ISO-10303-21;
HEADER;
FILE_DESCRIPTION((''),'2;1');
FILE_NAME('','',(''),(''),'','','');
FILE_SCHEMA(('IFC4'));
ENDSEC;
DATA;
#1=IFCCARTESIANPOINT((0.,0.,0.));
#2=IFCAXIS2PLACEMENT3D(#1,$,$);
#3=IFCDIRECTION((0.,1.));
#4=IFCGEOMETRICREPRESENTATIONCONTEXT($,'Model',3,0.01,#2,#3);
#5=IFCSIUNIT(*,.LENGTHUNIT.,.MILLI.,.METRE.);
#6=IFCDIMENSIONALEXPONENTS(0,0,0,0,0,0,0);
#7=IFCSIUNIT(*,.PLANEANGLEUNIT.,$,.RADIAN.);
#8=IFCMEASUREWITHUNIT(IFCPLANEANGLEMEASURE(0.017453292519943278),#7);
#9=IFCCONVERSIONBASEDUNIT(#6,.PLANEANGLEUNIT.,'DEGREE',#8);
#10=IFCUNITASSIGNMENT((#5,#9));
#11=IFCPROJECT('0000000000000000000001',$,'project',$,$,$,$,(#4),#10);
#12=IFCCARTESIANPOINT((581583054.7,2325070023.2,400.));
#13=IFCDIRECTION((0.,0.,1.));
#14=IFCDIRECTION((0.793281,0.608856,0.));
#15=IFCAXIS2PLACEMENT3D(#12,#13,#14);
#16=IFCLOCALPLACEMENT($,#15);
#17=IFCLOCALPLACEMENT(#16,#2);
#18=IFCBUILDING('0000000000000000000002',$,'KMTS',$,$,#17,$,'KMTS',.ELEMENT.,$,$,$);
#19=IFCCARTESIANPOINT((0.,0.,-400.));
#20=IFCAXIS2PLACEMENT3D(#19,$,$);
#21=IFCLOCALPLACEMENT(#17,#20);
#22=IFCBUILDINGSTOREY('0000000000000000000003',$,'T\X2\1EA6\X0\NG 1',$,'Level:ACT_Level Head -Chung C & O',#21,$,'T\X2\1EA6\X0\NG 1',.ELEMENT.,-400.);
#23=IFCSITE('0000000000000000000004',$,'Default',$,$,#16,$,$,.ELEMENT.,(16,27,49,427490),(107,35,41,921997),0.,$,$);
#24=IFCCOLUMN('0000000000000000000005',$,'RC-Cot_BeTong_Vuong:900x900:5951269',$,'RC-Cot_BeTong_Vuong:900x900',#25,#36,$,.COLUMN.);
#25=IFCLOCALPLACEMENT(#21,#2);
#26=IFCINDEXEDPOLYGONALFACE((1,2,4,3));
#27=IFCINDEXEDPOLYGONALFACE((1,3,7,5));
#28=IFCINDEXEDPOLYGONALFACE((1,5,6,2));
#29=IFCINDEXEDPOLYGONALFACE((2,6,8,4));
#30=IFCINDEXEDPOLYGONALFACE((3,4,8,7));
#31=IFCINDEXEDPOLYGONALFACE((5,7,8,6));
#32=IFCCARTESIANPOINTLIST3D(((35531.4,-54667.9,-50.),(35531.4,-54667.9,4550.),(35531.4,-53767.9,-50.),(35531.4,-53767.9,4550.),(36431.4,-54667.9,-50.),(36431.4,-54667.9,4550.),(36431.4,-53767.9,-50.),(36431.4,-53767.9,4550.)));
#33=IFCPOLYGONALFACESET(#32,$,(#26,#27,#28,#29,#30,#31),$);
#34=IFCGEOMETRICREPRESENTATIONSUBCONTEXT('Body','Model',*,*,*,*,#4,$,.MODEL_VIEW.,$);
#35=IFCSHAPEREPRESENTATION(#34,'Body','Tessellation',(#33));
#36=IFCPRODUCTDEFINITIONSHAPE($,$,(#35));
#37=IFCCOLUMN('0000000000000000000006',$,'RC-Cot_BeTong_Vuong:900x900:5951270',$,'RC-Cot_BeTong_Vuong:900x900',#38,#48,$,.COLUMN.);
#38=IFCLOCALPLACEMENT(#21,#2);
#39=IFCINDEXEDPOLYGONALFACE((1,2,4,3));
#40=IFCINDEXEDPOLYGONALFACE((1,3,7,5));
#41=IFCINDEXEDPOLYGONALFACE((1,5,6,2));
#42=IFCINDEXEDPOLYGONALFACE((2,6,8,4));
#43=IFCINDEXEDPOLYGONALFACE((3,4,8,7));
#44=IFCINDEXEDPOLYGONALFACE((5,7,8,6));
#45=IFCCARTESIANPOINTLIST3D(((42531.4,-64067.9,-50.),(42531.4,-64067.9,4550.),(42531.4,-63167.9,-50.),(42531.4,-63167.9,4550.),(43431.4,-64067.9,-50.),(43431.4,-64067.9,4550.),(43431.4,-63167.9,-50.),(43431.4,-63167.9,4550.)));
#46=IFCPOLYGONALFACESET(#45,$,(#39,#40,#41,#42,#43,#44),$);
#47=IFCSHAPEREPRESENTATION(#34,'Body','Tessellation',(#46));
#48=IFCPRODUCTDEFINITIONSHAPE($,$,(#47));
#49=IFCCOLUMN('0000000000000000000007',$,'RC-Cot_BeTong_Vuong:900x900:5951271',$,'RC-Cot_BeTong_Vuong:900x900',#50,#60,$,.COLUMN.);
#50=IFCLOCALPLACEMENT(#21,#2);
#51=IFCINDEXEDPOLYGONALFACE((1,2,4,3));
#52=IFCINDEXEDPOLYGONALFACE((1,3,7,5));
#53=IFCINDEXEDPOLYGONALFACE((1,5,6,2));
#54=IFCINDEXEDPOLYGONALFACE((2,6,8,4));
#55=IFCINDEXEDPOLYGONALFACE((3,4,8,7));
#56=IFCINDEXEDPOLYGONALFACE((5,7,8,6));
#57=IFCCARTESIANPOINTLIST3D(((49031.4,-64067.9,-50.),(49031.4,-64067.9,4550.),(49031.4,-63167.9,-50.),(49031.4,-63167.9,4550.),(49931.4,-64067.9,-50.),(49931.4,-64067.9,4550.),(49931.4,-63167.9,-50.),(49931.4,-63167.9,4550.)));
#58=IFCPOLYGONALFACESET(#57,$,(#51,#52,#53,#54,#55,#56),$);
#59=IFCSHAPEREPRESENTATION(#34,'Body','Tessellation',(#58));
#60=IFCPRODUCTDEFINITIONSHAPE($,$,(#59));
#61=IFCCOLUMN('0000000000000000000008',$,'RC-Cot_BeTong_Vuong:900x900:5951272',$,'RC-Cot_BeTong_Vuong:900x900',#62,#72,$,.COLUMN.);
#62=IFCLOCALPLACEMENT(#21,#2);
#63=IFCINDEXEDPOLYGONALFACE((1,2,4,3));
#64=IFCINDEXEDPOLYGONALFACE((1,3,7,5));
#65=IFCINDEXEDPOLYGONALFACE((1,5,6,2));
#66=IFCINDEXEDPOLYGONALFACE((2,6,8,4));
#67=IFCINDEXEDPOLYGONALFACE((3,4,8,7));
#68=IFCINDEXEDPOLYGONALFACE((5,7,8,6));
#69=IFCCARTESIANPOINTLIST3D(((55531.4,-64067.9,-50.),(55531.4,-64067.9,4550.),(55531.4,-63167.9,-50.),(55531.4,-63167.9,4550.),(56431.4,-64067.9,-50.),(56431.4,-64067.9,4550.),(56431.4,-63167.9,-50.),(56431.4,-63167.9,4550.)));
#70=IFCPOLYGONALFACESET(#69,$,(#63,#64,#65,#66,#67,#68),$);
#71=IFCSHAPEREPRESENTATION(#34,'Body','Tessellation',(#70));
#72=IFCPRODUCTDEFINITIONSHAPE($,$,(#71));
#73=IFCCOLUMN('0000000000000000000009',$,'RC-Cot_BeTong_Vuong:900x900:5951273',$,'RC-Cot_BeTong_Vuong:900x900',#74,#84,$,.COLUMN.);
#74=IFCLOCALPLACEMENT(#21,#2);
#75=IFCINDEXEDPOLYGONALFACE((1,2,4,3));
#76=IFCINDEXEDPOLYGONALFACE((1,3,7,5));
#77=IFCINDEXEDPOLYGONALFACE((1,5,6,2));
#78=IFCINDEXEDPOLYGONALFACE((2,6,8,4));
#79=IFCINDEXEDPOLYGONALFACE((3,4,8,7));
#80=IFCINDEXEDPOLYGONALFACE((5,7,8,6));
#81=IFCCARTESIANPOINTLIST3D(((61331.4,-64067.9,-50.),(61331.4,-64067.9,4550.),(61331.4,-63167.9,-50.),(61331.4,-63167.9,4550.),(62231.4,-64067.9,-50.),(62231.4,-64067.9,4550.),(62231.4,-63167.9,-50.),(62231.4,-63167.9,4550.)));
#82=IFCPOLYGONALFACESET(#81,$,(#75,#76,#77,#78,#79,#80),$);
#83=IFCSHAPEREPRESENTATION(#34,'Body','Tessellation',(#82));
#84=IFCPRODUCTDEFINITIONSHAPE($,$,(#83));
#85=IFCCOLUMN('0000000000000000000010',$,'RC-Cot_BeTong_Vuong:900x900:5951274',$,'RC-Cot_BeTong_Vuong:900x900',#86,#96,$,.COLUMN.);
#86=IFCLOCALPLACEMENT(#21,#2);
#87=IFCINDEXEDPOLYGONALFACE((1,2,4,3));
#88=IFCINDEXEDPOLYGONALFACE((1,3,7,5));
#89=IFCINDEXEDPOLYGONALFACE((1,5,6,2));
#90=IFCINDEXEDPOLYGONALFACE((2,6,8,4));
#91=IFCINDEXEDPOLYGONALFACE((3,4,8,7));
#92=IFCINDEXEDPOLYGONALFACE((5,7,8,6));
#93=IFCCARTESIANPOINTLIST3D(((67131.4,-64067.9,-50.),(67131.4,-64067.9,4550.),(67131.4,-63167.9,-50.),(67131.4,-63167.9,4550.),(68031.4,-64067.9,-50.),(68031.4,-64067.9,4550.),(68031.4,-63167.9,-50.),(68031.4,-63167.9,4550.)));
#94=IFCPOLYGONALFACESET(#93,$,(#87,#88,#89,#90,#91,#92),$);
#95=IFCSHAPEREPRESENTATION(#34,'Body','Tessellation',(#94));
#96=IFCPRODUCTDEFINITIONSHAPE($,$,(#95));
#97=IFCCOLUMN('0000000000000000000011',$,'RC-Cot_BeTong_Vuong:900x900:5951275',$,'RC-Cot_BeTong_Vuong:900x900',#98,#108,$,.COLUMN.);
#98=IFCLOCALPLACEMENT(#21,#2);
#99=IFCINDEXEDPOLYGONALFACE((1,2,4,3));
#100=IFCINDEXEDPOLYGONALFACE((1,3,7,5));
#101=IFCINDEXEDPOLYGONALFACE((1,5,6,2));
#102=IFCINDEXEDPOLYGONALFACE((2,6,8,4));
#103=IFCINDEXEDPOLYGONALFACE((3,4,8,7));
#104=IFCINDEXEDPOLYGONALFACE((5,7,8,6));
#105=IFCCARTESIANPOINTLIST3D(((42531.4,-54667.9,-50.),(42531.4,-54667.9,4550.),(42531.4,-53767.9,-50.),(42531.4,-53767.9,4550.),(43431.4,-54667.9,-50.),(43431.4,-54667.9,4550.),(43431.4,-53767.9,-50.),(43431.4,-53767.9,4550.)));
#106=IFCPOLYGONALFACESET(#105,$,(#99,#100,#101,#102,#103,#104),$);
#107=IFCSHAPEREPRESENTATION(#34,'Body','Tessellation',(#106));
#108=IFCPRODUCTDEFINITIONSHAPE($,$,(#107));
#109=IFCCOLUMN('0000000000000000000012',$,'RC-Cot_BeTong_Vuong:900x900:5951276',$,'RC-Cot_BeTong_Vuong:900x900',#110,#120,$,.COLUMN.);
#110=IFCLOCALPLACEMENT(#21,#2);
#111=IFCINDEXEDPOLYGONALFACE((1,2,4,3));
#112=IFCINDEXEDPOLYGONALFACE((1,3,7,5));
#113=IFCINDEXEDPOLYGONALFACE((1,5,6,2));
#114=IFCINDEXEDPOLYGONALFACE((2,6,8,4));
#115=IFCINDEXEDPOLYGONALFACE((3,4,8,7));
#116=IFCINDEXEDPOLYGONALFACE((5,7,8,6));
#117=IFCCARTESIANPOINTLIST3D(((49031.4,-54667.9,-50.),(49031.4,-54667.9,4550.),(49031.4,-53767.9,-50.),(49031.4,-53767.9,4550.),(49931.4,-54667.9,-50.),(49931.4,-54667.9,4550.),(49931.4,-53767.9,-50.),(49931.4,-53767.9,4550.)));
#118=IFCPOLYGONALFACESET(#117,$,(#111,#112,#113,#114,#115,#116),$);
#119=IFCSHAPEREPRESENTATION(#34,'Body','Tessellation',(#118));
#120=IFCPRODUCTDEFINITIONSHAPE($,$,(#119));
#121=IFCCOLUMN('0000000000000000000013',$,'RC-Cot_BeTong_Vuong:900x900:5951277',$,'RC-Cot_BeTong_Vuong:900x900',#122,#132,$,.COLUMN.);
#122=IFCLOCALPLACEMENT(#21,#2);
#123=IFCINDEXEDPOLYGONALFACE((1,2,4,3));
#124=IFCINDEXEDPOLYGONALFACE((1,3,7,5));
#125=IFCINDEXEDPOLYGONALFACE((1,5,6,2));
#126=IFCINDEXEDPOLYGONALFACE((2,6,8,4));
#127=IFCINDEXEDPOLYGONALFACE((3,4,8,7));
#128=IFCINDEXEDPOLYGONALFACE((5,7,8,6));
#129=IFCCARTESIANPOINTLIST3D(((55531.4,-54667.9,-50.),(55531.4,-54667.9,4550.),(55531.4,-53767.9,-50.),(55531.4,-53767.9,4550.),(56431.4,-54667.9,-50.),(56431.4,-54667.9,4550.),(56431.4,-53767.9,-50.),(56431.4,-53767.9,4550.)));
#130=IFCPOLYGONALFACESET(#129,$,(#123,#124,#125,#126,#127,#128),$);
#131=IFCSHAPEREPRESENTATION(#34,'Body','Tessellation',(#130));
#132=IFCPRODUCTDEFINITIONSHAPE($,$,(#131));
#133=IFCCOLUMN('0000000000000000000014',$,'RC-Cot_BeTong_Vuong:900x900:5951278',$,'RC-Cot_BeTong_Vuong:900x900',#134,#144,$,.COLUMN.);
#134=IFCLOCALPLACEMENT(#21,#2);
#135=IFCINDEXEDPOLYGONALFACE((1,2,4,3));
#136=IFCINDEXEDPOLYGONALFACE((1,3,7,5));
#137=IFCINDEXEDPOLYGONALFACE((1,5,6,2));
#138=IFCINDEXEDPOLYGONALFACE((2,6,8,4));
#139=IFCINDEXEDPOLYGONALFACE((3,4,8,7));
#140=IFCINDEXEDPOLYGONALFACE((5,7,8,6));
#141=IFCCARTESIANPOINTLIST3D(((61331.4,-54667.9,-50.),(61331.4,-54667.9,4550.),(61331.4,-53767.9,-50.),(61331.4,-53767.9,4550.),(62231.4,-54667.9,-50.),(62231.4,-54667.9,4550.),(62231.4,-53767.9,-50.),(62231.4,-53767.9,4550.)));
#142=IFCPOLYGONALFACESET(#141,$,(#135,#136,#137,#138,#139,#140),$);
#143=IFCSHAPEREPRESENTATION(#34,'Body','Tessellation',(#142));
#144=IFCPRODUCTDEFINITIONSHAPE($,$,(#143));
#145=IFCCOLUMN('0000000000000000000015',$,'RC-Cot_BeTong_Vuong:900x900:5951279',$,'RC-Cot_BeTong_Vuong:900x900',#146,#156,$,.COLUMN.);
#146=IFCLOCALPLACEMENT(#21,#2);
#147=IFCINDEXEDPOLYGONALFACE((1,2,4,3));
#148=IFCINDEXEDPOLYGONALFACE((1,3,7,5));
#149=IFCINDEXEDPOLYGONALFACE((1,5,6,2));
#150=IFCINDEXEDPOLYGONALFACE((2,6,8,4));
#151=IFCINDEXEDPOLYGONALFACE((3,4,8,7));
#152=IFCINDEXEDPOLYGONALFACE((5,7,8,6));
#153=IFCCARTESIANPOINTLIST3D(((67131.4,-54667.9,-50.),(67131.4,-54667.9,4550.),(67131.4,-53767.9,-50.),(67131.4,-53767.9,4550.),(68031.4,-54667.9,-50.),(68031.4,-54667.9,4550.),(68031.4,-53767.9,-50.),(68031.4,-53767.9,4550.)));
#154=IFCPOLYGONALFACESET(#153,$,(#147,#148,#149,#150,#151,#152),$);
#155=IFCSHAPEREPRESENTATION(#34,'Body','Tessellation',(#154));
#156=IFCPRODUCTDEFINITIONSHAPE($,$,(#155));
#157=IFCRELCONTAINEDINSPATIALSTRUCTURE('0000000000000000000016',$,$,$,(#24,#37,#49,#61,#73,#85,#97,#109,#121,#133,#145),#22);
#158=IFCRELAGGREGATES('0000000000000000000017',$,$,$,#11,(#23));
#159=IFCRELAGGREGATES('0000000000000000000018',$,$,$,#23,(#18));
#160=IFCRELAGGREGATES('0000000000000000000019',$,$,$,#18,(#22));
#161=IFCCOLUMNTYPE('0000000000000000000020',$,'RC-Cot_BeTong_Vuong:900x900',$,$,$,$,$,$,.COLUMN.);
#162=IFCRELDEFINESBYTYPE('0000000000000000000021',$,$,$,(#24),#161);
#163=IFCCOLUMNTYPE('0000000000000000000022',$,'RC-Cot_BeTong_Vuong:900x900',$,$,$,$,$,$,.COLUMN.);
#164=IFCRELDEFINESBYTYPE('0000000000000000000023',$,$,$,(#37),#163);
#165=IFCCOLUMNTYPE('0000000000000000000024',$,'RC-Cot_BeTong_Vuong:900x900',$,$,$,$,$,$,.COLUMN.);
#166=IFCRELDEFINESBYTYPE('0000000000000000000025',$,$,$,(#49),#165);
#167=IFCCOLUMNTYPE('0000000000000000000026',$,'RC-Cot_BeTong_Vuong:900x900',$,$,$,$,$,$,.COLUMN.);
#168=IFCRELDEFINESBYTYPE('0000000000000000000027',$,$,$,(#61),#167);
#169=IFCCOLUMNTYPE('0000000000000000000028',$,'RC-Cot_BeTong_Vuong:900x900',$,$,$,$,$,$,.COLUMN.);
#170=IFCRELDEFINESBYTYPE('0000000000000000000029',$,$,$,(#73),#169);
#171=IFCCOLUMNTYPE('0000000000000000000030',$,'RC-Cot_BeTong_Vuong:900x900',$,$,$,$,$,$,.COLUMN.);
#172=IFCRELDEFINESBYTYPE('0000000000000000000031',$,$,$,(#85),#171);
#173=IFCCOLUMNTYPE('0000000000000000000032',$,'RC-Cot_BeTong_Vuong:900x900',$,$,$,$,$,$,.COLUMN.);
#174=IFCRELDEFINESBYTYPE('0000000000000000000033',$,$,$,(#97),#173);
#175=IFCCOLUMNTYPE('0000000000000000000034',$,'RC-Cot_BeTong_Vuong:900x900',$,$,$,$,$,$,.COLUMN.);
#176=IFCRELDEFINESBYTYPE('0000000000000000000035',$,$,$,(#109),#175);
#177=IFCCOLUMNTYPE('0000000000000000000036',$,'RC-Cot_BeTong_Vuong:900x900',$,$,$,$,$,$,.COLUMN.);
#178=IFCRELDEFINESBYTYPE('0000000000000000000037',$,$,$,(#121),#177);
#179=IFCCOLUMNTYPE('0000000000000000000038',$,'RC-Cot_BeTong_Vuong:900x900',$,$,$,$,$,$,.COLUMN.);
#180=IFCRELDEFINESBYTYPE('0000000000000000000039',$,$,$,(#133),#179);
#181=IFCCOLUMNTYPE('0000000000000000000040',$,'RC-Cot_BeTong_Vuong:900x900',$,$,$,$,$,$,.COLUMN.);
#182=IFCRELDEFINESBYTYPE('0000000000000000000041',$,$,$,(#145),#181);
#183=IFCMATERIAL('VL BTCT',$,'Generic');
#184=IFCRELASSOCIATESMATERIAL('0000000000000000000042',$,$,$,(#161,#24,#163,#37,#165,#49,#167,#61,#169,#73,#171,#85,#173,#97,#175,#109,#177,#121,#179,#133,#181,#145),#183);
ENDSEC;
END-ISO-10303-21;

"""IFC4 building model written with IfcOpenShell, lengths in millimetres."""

from ifc_helpers import new_model, entity, si_unit, converted_unit, direction, frame, origin, place, context, subcontext, project, spatial, indexed_curve, outline, extrude, source, transform, mapped, material, type_object, type_shapes, element, save


model = new_model("IFC4")

# Units and contexts
model_context = context("Model", 3, precision=0.01, world=origin(), true_north=direction((0.0, 1.0)))
body_context = subcontext(model_context, "Body", "Model", "MODEL_VIEW")
ifc_project = project(units=[si_unit("LENGTHUNIT", "METRE", prefix="MILLI"), converted_unit("PLANEANGLEUNIT", "DEGREE", entity("IfcPlaneAngleMeasure", 0.017453292519943278), si_unit("PLANEANGLEUNIT", "RADIAN"), dimensions=[0, 0, 0, 0, 0, 0, 0])], contexts=[model_context])

# Site, building, storey
site_placement = place(None, frame((581583054.7, 2325070023.2, 400.0), z_axis=(0.0, 0.0, 1.0), x_axis=(0.793281, 0.608856, 0.0)))
site = spatial("IfcSite", under=ifc_project, at=site_placement, Name="Default", CompositionType="ELEMENT", RefLatitude=(16, 27, 49, 427490), RefLongitude=(107, 35, 41, 921997), RefElevation=0.0)
building_placement = place(site_placement, origin())
building = spatial("IfcBuilding", under=site, at=building_placement, Name="KMTS", LongName="KMTS", CompositionType="ELEMENT")
storey_placement = place(building_placement, frame((0.0, 0.0, -400.0)))
storey = spatial("IfcBuildingStorey", under=building, at=storey_placement, Name="TẦNG 1", ObjectType="Level:ACT_Level Head -Chung C & O", LongName="TẦNG 1", CompositionType="ELEMENT", Elevation=-400.0)

# Columns
ifc_material = material(Name="VL BTCT", Category="Generic")
column_type_1 = type_object("IfcColumnType", Name="RC-Cot_BeTong_Vuong:900x900", PredefinedType="COLUMN", material=ifc_material)
shared_shape_1 = source(origin(), body_context, "Body", "SweptSolid", [
    extrude(outline(indexed_curve([(-450.0, -450.0), (450.0, -450.0), (450.0, 450.0), (-450.0, 450.0), (-450.0, -450.0)], self_intersect=False)), frame((35981.4, -54217.9, -450.0), z_axis=(0.0, 0.0, 1.0), x_axis=(-1.0, 0.0, 0.0)), (0.0, 0.0, 1.0), 4600.0),
])
type_shapes(column_type_1, [shared_shape_1])
column_1_placement = place(storey_placement, frame((0.0, 0.0, 400.0)))
element("IfcColumn", 1, at=column_1_placement, inside=storey, type_object=column_type_1, material=ifc_material, Name="RC-Cot_BeTong_Vuong:900x900:5951269", ObjectType="RC-Cot_BeTong_Vuong:900x900", PredefinedType="COLUMN", context=body_context, shape_type="MappedRepresentation", body=[
    mapped(shared_shape_1, transform((0.0, 0.0, 0.0), scale=1.0)),
])
column_type_2 = type_object("IfcColumnType", Name="RC-Cot_BeTong_Vuong:900x900", PredefinedType="COLUMN", material=ifc_material)
shared_shape_2 = source(origin(), body_context, "Body", "SweptSolid", [
    extrude(outline(indexed_curve([(-450.0, -450.0), (450.0, -450.0), (450.0, 450.0), (-450.0, 450.0), (-450.0, -450.0)], self_intersect=False)), frame((42981.4, -63617.9, -450.0), z_axis=(0.0, 0.0, 1.0), x_axis=(-1.0, 0.0, 0.0)), (0.0, 0.0, 1.0), 4600.0),
])
type_shapes(column_type_2, [shared_shape_2])
column_2_placement = place(storey_placement, frame((0.0, 0.0, 400.0)))
element("IfcColumn", 2, at=column_2_placement, inside=storey, type_object=column_type_2, material=ifc_material, Name="RC-Cot_BeTong_Vuong:900x900:5951270", ObjectType="RC-Cot_BeTong_Vuong:900x900", PredefinedType="COLUMN", context=body_context, shape_type="MappedRepresentation", body=[
    mapped(shared_shape_2, transform((0.0, 0.0, 0.0), scale=1.0)),
])
column_type_3 = type_object("IfcColumnType", Name="RC-Cot_BeTong_Vuong:900x900", PredefinedType="COLUMN", material=ifc_material)
shared_shape_3 = source(origin(), body_context, "Body", "SweptSolid", [
    extrude(outline(indexed_curve([(-450.0, -450.0), (450.0, -450.0), (450.0, 450.0), (-450.0, 450.0), (-450.0, -450.0)], self_intersect=False)), frame((49481.4, -63617.9, -450.0), z_axis=(0.0, 0.0, 1.0), x_axis=(-1.0, 0.0, 0.0)), (0.0, 0.0, 1.0), 4600.0),
])
type_shapes(column_type_3, [shared_shape_3])
column_3_placement = place(storey_placement, frame((0.0, 0.0, 400.0)))
element("IfcColumn", 3, at=column_3_placement, inside=storey, type_object=column_type_3, material=ifc_material, Name="RC-Cot_BeTong_Vuong:900x900:5951271", ObjectType="RC-Cot_BeTong_Vuong:900x900", PredefinedType="COLUMN", context=body_context, shape_type="MappedRepresentation", body=[
    mapped(shared_shape_3, transform((0.0, 0.0, 0.0), scale=1.0)),
])
column_type_4 = type_object("IfcColumnType", Name="RC-Cot_BeTong_Vuong:900x900", PredefinedType="COLUMN", material=ifc_material)
shared_shape_4 = source(origin(), body_context, "Body", "SweptSolid", [
    extrude(outline(indexed_curve([(-450.0, -450.0), (450.0, -450.0), (450.0, 450.0), (-450.0, 450.0), (-450.0, -450.0)], self_intersect=False)), frame((55981.4, -63617.9, -450.0), z_axis=(0.0, 0.0, 1.0), x_axis=(-1.0, 0.0, 0.0)), (0.0, 0.0, 1.0), 4600.0),
])
type_shapes(column_type_4, [shared_shape_4])
column_4_placement = place(storey_placement, frame((0.0, 0.0, 400.0)))
element("IfcColumn", 4, at=column_4_placement, inside=storey, type_object=column_type_4, material=ifc_material, Name="RC-Cot_BeTong_Vuong:900x900:5951272", ObjectType="RC-Cot_BeTong_Vuong:900x900", PredefinedType="COLUMN", context=body_context, shape_type="MappedRepresentation", body=[
    mapped(shared_shape_4, transform((0.0, 0.0, 0.0), scale=1.0)),
])
column_type_5 = type_object("IfcColumnType", Name="RC-Cot_BeTong_Vuong:900x900", PredefinedType="COLUMN", material=ifc_material)
shared_shape_5 = source(origin(), body_context, "Body", "SweptSolid", [
    extrude(outline(indexed_curve([(-450.0, -450.0), (450.0, -450.0), (450.0, 450.0), (-450.0, 450.0), (-450.0, -450.0)], self_intersect=False)), frame((61781.4, -63617.9, -450.0), z_axis=(0.0, 0.0, 1.0), x_axis=(-1.0, 0.0, 0.0)), (0.0, 0.0, 1.0), 4600.0),
])
type_shapes(column_type_5, [shared_shape_5])
column_5_placement = place(storey_placement, frame((0.0, 0.0, 400.0)))
element("IfcColumn", 5, at=column_5_placement, inside=storey, type_object=column_type_5, material=ifc_material, Name="RC-Cot_BeTong_Vuong:900x900:5951273", ObjectType="RC-Cot_BeTong_Vuong:900x900", PredefinedType="COLUMN", context=body_context, shape_type="MappedRepresentation", body=[
    mapped(shared_shape_5, transform((0.0, 0.0, 0.0), scale=1.0)),
])
column_type_6 = type_object("IfcColumnType", Name="RC-Cot_BeTong_Vuong:900x900", PredefinedType="COLUMN", material=ifc_material)
shared_shape_6 = source(origin(), body_context, "Body", "SweptSolid", [
    extrude(outline(indexed_curve([(-450.0, -450.0), (450.0, -450.0), (450.0, 450.0), (-450.0, 450.0), (-450.0, -450.0)], self_intersect=False)), frame((67581.4, -63617.9, -450.0), z_axis=(0.0, 0.0, 1.0), x_axis=(-1.0, 0.0, 0.0)), (0.0, 0.0, 1.0), 4600.0),
])
type_shapes(column_type_6, [shared_shape_6])
column_6_placement = place(storey_placement, frame((0.0, 0.0, 400.0)))
element("IfcColumn", 6, at=column_6_placement, inside=storey, type_object=column_type_6, material=ifc_material, Name="RC-Cot_BeTong_Vuong:900x900:5951274", ObjectType="RC-Cot_BeTong_Vuong:900x900", PredefinedType="COLUMN", context=body_context, shape_type="MappedRepresentation", body=[
    mapped(shared_shape_6, transform((0.0, 0.0, 0.0), scale=1.0)),
])
column_type_7 = type_object("IfcColumnType", Name="RC-Cot_BeTong_Vuong:900x900", PredefinedType="COLUMN", material=ifc_material)
shared_shape_7 = source(origin(), body_context, "Body", "SweptSolid", [
    extrude(outline(indexed_curve([(-450.0, -450.0), (450.0, -450.0), (450.0, 450.0), (-450.0, 450.0), (-450.0, -450.0)], self_intersect=False)), frame((42981.4, -54217.9, -450.0), z_axis=(0.0, 0.0, 1.0), x_axis=(-1.0, 0.0, 0.0)), (0.0, 0.0, 1.0), 4600.0),
])
type_shapes(column_type_7, [shared_shape_7])
column_7_placement = place(storey_placement, frame((0.0, 0.0, 400.0)))
element("IfcColumn", 7, at=column_7_placement, inside=storey, type_object=column_type_7, material=ifc_material, Name="RC-Cot_BeTong_Vuong:900x900:5951275", ObjectType="RC-Cot_BeTong_Vuong:900x900", PredefinedType="COLUMN", context=body_context, shape_type="MappedRepresentation", body=[
    mapped(shared_shape_7, transform((0.0, 0.0, 0.0), scale=1.0)),
])
column_type_8 = type_object("IfcColumnType", Name="RC-Cot_BeTong_Vuong:900x900", PredefinedType="COLUMN", material=ifc_material)
shared_shape_8 = source(origin(), body_context, "Body", "SweptSolid", [
    extrude(outline(indexed_curve([(-450.0, -450.0), (450.0, -450.0), (450.0, 450.0), (-450.0, 450.0), (-450.0, -450.0)], self_intersect=False)), frame((49481.4, -54217.9, -450.0), z_axis=(0.0, 0.0, 1.0), x_axis=(-1.0, 0.0, 0.0)), (0.0, 0.0, 1.0), 4600.0),
])
type_shapes(column_type_8, [shared_shape_8])
column_8_placement = place(storey_placement, frame((0.0, 0.0, 400.0)))
element("IfcColumn", 8, at=column_8_placement, inside=storey, type_object=column_type_8, material=ifc_material, Name="RC-Cot_BeTong_Vuong:900x900:5951276", ObjectType="RC-Cot_BeTong_Vuong:900x900", PredefinedType="COLUMN", context=body_context, shape_type="MappedRepresentation", body=[
    mapped(shared_shape_8, transform((0.0, 0.0, 0.0), scale=1.0)),
])
column_type_9 = type_object("IfcColumnType", Name="RC-Cot_BeTong_Vuong:900x900", PredefinedType="COLUMN", material=ifc_material)
shared_shape_9 = source(origin(), body_context, "Body", "SweptSolid", [
    extrude(outline(indexed_curve([(-450.0, -450.0), (450.0, -450.0), (450.0, 450.0), (-450.0, 450.0), (-450.0, -450.0)], self_intersect=False)), frame((55981.4, -54217.9, -450.0), z_axis=(0.0, 0.0, 1.0), x_axis=(-1.0, 0.0, 0.0)), (0.0, 0.0, 1.0), 4600.0),
])
type_shapes(column_type_9, [shared_shape_9])
column_9_placement = place(storey_placement, frame((0.0, 0.0, 400.0)))
element("IfcColumn", 9, at=column_9_placement, inside=storey, type_object=column_type_9, material=ifc_material, Name="RC-Cot_BeTong_Vuong:900x900:5951277", ObjectType="RC-Cot_BeTong_Vuong:900x900", PredefinedType="COLUMN", context=body_context, shape_type="MappedRepresentation", body=[
    mapped(shared_shape_9, transform((0.0, 0.0, 0.0), scale=1.0)),
])
column_type_10 = type_object("IfcColumnType", Name="RC-Cot_BeTong_Vuong:900x900", PredefinedType="COLUMN", material=ifc_material)
shared_shape_10 = source(origin(), body_context, "Body", "SweptSolid", [
    extrude(outline(indexed_curve([(-450.0, -450.0), (450.0, -450.0), (450.0, 450.0), (-450.0, 450.0), (-450.0, -450.0)], self_intersect=False)), frame((61781.4, -54217.9, -450.0), z_axis=(0.0, 0.0, 1.0), x_axis=(-1.0, 0.0, 0.0)), (0.0, 0.0, 1.0), 4600.0),
])
type_shapes(column_type_10, [shared_shape_10])
column_10_placement = place(storey_placement, frame((0.0, 0.0, 400.0)))
element("IfcColumn", 10, at=column_10_placement, inside=storey, type_object=column_type_10, material=ifc_material, Name="RC-Cot_BeTong_Vuong:900x900:5951278", ObjectType="RC-Cot_BeTong_Vuong:900x900", PredefinedType="COLUMN", context=body_context, shape_type="MappedRepresentation", body=[
    mapped(shared_shape_10, transform((0.0, 0.0, 0.0), scale=1.0)),
])
column_type_11 = type_object("IfcColumnType", Name="RC-Cot_BeTong_Vuong:900x900", PredefinedType="COLUMN", material=ifc_material)
shared_shape_11 = source(origin(), body_context, "Body", "SweptSolid", [
    extrude(outline(indexed_curve([(-450.0, -450.0), (450.0, -450.0), (450.0, 450.0), (-450.0, 450.0), (-450.0, -450.0)], self_intersect=False)), frame((67581.4, -54217.9, -450.0), z_axis=(0.0, 0.0, 1.0), x_axis=(-1.0, 0.0, 0.0)), (0.0, 0.0, 1.0), 4600.0),
])
type_shapes(column_type_11, [shared_shape_11])
column_11_placement = place(storey_placement, frame((0.0, 0.0, 400.0)))
element("IfcColumn", 11, at=column_11_placement, inside=storey, type_object=column_type_11, material=ifc_material, Name="RC-Cot_BeTong_Vuong:900x900:5951279", ObjectType="RC-Cot_BeTong_Vuong:900x900", PredefinedType="COLUMN", context=body_context, shape_type="MappedRepresentation", body=[
    mapped(shared_shape_11, transform((0.0, 0.0, 0.0), scale=1.0)),
])

save(model, "model.ifc")
